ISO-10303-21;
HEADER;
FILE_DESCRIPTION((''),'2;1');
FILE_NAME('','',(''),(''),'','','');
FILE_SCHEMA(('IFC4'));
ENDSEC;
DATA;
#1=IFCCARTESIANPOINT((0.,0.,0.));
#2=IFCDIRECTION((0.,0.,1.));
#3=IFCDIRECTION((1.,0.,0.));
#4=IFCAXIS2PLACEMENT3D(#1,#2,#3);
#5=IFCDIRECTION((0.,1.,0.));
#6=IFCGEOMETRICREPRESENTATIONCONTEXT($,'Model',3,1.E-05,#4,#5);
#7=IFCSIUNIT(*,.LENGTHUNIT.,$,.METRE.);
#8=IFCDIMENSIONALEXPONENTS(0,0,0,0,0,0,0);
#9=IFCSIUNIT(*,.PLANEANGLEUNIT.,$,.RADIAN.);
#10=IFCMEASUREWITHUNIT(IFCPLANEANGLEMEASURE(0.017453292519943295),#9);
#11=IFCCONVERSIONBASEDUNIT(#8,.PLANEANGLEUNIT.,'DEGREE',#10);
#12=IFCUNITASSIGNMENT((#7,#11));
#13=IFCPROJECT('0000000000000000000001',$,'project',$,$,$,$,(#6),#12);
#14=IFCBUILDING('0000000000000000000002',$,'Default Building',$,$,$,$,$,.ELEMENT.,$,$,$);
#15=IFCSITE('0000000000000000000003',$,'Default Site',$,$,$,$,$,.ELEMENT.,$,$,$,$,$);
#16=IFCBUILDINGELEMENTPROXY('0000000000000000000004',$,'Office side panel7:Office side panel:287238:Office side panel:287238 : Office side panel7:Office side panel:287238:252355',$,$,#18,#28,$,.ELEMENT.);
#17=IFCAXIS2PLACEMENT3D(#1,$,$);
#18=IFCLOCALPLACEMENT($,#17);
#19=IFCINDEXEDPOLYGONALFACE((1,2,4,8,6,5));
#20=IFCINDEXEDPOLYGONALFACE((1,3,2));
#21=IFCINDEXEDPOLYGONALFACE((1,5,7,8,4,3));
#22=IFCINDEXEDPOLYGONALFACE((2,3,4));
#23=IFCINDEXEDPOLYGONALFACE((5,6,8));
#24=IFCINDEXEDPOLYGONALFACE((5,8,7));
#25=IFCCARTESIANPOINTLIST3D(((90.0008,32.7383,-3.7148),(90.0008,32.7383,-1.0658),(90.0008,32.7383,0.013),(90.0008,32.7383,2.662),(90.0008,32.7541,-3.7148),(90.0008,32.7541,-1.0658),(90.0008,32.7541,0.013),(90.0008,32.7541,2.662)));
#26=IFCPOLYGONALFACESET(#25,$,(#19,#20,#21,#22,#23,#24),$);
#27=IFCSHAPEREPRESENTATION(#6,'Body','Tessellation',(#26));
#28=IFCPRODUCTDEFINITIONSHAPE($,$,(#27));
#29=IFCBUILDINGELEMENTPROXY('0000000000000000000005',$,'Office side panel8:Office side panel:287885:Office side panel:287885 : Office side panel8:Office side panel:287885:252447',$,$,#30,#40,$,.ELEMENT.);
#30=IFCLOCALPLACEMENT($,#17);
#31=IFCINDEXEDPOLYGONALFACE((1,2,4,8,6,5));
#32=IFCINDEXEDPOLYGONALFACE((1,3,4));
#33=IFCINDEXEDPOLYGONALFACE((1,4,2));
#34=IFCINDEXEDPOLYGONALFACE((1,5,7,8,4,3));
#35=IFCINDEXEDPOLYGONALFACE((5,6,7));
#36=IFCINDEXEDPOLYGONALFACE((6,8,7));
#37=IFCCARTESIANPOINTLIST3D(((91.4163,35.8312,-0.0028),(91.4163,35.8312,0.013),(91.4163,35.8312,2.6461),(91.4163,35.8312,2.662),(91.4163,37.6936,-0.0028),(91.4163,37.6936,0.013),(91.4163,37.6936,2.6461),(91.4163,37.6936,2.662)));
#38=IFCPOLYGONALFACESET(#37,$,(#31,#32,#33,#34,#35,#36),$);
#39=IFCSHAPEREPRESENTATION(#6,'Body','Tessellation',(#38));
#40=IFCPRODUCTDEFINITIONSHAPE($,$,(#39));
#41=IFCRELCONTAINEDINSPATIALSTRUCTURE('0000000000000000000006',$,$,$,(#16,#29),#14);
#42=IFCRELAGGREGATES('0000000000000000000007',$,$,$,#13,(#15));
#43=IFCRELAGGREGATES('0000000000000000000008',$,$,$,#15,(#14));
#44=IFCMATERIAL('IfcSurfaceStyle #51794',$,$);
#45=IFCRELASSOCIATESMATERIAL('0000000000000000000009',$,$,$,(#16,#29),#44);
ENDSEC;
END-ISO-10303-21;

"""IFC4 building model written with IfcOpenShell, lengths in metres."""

from ifc_helpers import new_model, entity, si_unit, converted_unit, direction, frame, origin_with_axes, place, context, project, spatial, polyline, outline, extrude, material, element, save


model = new_model("IFC4")

# Units and contexts
model_context = context("Model", 3, precision=1e-05, world=origin_with_axes(), true_north=direction((0.0, 1.0, 0.0)))
ifc_project = project(units=[si_unit("LENGTHUNIT", "METRE"), converted_unit("PLANEANGLEUNIT", "DEGREE", entity("IfcPlaneAngleMeasure", 0.017453292519943295), si_unit("PLANEANGLEUNIT", "RADIAN"), dimensions=[0, 0, 0, 0, 0, 0, 0])], contexts=[model_context])

# Site, building
site = spatial("IfcSite", under=ifc_project, Name="Default Site", CompositionType="ELEMENT")
building = spatial("IfcBuilding", under=site, Name="Default Building", CompositionType="ELEMENT")

# Building element proxies
ifc_material_1 = material(Name="IfcSurfaceStyle #51794")
proxy_1_placement = place(None, origin_with_axes())
element("IfcBuildingElementProxy", 1, at=proxy_1_placement, inside=building, material=ifc_material_1, Name="Office side panel7:Office side panel:287238:Office side panel:287238 : Office side panel7:Office side panel:287238:252355", PredefinedType="ELEMENT", context=model_context, shape_type="SweptSolid", body=[
    extrude(outline(polyline([(1.3245, 0.0079), (-1.3245, 0.0079), (-1.3245, -0.0079), (1.3245, -0.0079), (1.3245, 0.0079)])), frame((90.0008, 32.7462, 1.3375), z_axis=(1.0, 0.0, 0.0), x_axis=(0.0, 0.0, -1.0)), (1.0, 0.0, 0.0), 3.7278),
])
proxy_2_placement = place(None, origin_with_axes())
element("IfcBuildingElementProxy", 2, at=proxy_2_placement, inside=building, material=ifc_material_1, Name="Office side panel8:Office side panel:287885:Office side panel:287885 : Office side panel8:Office side panel:287885:252447", PredefinedType="ELEMENT", context=model_context, shape_type="SweptSolid", body=[
    extrude(outline(polyline([(-1.3245, -0.9312), (1.3245, -0.9312), (1.3245, 0.9312), (-1.3245, 0.9312), (-1.3245, -0.9312)])), frame((91.4163, 36.7624, 1.3375), z_axis=(-1.0, 0.0, 0.0), x_axis=(0.0, 0.0, 1.0)), (-1.0, 0.0, 0.0), 0.0159),
])

save(model, "model.ifc")
